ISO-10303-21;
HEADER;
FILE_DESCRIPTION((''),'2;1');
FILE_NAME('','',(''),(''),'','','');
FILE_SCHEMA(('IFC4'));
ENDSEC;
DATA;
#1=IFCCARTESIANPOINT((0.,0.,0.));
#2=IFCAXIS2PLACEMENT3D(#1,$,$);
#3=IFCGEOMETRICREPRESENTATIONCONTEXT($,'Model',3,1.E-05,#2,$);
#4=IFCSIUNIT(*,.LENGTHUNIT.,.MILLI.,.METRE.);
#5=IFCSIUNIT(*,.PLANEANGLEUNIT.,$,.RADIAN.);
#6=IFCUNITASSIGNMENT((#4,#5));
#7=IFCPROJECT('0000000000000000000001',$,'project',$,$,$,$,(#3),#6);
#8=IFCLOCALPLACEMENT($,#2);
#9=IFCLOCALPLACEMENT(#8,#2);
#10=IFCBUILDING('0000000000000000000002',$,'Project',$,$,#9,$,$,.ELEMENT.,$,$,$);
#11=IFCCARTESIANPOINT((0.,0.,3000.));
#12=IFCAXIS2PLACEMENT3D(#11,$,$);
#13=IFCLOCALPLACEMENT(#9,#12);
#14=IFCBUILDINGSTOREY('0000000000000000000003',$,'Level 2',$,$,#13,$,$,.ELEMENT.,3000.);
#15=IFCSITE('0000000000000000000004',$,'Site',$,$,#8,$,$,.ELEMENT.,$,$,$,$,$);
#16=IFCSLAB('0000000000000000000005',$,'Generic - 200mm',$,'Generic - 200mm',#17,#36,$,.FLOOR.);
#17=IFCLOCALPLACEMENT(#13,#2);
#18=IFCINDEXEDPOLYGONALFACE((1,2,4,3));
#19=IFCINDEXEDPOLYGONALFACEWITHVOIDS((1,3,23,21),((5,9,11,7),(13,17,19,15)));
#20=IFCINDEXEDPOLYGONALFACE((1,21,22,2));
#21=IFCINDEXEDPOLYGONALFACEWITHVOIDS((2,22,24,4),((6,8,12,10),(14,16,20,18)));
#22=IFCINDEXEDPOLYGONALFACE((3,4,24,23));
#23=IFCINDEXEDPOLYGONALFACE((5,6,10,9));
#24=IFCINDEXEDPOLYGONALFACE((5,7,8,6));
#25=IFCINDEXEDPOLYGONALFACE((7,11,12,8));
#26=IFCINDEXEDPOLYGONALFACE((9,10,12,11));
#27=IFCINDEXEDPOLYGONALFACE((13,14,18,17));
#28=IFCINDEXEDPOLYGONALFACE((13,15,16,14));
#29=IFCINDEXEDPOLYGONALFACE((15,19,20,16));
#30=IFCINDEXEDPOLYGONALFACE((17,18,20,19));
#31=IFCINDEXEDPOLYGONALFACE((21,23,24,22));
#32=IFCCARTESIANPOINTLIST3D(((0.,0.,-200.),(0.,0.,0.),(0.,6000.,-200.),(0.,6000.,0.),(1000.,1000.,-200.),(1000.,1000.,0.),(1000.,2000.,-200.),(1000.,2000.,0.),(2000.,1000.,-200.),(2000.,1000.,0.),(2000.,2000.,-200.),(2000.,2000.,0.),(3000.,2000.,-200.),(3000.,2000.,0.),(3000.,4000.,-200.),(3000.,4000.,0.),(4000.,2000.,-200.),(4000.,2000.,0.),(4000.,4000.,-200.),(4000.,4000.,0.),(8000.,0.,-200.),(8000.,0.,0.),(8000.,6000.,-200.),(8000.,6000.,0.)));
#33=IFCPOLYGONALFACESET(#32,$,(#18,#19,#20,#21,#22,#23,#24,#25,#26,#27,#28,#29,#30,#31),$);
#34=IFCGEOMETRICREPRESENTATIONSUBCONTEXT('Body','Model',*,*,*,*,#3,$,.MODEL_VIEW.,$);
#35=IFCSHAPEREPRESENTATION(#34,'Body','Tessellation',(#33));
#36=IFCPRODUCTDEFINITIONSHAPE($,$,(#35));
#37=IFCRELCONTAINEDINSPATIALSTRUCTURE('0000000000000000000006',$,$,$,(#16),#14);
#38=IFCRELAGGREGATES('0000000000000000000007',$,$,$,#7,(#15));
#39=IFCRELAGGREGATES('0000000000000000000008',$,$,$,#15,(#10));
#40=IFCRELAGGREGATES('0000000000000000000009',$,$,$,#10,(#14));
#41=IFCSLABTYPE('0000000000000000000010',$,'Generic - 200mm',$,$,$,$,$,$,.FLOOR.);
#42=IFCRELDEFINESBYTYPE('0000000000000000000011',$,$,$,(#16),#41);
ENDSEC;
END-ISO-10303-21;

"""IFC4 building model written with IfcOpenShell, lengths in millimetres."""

from ifc_helpers import new_model, si_unit, frame, origin, place, context, subcontext, project, spatial, polyline, outline, extrude, type_object, element, save


model = new_model("IFC4")

# Units and contexts
model_context = context("Model", 3, precision=1e-05, world=origin())
body_context = subcontext(model_context, "Body", "Model", "MODEL_VIEW")
ifc_project = project(units=[si_unit("LENGTHUNIT", "METRE", prefix="MILLI"), si_unit("PLANEANGLEUNIT", "RADIAN")], contexts=[model_context])

# Site, building, storey
site_placement = place(None, origin())
site = spatial("IfcSite", under=ifc_project, at=site_placement, Name="Site", CompositionType="ELEMENT")
building_placement = place(site_placement, origin())
building = spatial("IfcBuilding", under=site, at=building_placement, Name="Project", CompositionType="ELEMENT")
storey_placement = place(building_placement, frame((0.0, 0.0, 3000.0)))
storey = spatial("IfcBuildingStorey", under=building, at=storey_placement, Name="Level 2", CompositionType="ELEMENT", Elevation=3000.0)

# Slab, opening
slab_type = type_object("IfcSlabType", Name="Generic - 200mm", PredefinedType="FLOOR")
slab_placement = place(storey_placement, origin())
slab = element("IfcSlab", 1, at=slab_placement, inside=storey, type_object=slab_type, Name="Generic - 200mm", ObjectType="Generic - 200mm", PredefinedType="FLOOR", context=body_context, shape_type="SweptSolid", body=[
    extrude(outline(polyline([(0.0, 0.0), (8000.0, 0.0), (8000.0, 6000.0), (0.0, 6000.0), (0.0, 0.0)]), holes=[polyline([(1000.0, 1000.0), (2000.0, 1000.0), (2000.0, 2000.0), (1000.0, 2000.0), (1000.0, 1000.0)])]), frame((0.0, 0.0, -200.0)), (0.0, 0.0, 1.0), 200.0),
])
opening_placement = place(slab_placement, frame((0.0, 0.0, -3000.0)))
element("IfcOpeningElement", 2, at=opening_placement, cuts=slab, PredefinedType="OPENING", context=body_context, shape_type="SweptSolid", body=[
    extrude(outline(polyline([(3000.0, 2000.0), (4000.0, 2000.0), (4000.0, 4000.0), (3000.0, 4000.0), (3000.0, 2000.0)])), origin(), (0.0, 0.0, 1.0), 8000.0),
])

save(model, "model.ifc")
